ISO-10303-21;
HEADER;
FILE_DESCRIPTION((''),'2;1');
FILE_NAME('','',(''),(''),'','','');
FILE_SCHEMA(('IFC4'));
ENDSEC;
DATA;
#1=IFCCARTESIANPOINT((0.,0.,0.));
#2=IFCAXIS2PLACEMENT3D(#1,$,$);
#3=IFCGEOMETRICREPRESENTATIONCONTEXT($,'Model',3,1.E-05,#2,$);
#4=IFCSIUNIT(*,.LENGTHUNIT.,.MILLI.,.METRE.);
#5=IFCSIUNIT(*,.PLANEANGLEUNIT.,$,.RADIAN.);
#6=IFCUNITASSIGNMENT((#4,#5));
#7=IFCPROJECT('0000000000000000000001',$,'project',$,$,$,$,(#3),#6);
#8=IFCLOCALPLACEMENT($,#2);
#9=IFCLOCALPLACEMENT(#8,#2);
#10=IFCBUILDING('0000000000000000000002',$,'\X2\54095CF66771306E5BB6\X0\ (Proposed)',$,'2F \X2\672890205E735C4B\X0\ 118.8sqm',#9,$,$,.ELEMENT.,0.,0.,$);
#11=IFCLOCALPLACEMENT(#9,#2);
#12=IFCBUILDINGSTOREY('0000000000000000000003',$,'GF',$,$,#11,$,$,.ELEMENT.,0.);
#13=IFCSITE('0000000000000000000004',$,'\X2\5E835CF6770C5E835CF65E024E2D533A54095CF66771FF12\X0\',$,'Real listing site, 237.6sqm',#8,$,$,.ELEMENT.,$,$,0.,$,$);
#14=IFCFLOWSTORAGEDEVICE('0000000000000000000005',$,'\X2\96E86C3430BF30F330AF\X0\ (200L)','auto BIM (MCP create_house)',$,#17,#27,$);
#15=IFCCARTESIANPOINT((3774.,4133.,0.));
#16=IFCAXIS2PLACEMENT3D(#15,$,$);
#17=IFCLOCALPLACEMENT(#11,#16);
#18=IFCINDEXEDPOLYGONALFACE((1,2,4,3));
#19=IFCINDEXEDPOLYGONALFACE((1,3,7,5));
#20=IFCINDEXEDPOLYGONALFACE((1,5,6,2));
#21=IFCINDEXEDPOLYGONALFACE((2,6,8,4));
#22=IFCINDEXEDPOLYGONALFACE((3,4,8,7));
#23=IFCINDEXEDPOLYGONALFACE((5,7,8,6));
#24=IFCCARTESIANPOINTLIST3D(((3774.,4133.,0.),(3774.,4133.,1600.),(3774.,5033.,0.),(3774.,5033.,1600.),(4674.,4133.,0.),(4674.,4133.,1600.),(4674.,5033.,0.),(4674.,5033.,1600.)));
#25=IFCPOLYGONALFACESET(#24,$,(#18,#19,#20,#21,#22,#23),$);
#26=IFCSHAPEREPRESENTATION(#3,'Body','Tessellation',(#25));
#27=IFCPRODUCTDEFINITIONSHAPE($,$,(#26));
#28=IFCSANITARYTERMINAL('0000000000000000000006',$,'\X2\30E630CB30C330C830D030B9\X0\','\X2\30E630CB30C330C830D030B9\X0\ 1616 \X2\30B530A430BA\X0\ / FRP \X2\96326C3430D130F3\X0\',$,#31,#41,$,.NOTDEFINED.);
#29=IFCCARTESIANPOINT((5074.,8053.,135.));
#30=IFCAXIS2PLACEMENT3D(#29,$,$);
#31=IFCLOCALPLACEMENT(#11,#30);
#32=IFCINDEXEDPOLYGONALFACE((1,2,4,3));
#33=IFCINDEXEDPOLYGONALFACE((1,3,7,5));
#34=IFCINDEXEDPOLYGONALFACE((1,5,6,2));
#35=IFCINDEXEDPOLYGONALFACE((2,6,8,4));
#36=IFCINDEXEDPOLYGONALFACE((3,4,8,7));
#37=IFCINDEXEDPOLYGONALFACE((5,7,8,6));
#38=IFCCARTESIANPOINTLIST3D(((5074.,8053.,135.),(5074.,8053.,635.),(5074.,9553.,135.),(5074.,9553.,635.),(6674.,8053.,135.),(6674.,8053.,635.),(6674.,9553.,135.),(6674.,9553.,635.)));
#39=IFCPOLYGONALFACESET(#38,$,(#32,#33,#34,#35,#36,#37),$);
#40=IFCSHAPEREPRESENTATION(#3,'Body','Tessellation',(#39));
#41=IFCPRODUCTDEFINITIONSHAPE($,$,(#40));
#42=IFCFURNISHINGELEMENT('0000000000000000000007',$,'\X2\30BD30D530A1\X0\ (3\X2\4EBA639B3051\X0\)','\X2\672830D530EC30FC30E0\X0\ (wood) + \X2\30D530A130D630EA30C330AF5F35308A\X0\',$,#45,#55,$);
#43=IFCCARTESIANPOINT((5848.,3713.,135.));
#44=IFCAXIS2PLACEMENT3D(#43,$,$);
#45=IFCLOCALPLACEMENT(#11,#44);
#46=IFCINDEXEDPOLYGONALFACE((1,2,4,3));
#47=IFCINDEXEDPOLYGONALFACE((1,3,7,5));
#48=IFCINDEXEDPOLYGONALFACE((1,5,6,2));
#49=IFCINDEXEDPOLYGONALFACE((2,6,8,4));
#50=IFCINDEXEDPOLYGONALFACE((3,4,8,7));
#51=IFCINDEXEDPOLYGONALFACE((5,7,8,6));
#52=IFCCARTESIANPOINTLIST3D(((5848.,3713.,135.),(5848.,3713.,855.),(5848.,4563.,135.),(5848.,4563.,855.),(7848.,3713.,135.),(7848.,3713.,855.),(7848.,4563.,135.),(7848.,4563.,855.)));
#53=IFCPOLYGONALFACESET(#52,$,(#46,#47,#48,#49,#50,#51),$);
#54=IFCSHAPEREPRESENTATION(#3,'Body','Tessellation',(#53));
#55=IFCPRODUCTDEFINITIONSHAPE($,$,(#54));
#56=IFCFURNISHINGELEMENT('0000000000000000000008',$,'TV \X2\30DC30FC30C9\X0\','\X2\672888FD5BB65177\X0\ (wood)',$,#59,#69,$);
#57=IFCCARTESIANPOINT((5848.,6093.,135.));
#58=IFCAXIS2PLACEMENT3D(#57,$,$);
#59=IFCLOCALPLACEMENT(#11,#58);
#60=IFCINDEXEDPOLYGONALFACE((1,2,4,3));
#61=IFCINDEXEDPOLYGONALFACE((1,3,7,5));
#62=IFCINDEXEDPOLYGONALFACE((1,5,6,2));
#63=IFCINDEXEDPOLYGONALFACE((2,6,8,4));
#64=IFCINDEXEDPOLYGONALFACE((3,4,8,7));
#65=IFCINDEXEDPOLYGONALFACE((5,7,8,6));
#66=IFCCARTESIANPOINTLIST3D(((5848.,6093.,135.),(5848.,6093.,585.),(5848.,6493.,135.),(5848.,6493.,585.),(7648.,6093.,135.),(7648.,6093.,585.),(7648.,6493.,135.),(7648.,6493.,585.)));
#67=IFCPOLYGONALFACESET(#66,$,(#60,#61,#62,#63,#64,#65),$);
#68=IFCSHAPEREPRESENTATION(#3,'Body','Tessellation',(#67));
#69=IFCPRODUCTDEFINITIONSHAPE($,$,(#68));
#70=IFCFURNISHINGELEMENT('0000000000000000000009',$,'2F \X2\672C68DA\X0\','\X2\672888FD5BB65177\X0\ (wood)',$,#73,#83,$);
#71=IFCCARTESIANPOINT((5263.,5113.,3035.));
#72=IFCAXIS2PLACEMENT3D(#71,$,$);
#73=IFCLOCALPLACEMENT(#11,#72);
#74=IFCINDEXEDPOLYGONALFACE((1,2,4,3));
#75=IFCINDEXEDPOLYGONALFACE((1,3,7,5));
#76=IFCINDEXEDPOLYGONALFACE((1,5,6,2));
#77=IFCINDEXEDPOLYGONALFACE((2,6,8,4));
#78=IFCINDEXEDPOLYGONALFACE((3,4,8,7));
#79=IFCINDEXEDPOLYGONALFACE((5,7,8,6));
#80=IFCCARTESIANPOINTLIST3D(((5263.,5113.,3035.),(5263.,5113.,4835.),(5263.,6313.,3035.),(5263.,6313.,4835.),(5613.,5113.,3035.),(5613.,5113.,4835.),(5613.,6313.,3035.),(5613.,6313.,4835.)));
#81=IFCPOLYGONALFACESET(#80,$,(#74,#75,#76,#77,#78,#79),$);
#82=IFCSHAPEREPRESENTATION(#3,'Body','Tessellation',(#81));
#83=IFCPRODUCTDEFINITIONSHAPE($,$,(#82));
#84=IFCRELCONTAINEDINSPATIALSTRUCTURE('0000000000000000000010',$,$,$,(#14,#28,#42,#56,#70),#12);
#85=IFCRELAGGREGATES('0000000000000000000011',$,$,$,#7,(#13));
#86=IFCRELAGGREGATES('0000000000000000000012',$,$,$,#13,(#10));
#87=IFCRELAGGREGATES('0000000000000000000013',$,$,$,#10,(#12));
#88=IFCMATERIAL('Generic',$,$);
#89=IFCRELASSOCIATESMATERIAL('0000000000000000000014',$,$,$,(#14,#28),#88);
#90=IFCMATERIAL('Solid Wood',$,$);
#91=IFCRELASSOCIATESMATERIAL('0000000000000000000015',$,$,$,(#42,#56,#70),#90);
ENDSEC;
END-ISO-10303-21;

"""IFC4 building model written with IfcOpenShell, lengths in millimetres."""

from ifc_helpers import new_model, si_unit, frame, frame_2d, origin, place, context, project, spatial, rectangle, extrude, material, element, save


model = new_model("IFC4")

# Units and contexts
model_context = context("Model", 3, precision=1e-05, world=origin())
ifc_project = project(units=[si_unit("LENGTHUNIT", "METRE", prefix="MILLI"), si_unit("PLANEANGLEUNIT", "RADIAN")], contexts=[model_context])

# Site, building, storey
site_placement = place(None, origin())
site = spatial("IfcSite", under=ifc_project, at=site_placement, Name="広島県広島市中区吉島東２", ObjectType="Real listing site, 237.6sqm", CompositionType="ELEMENT", RefElevation=0.0)
building_placement = place(site_placement, origin())
building = spatial("IfcBuilding", under=site, at=building_placement, Name="吉島東の家 (Proposed)", ObjectType="2F 木造平屋 118.8sqm", CompositionType="ELEMENT", ElevationOfRefHeight=0.0, ElevationOfTerrain=0.0)
storey_placement = place(building_placement, origin())
storey = spatial("IfcBuildingStorey", under=building, at=storey_placement, Name="GF", CompositionType="ELEMENT", Elevation=0.0)

# Shared definitions
ifc_material_1 = material(Name="Solid Wood")

# Shared definitions
ifc_material_2 = material(Name="Generic")

# Flow storage device
flow_storage_device_placement = place(storey_placement, frame((3774.0, 4133.0, 0.0)))
element("IfcFlowStorageDevice", 1, at=flow_storage_device_placement, inside=storey, material=ifc_material_2, Name="雨水タンク (200L)", Description="auto BIM (MCP create_house)", context=model_context, shape_type="SweptSolid", body=[
    extrude(rectangle(XDim=900.0, YDim=900.0, at=frame_2d((450.0, 450.0))), frame((3774.0, 4133.0, 0.0)), (0.0, 0.0, 1.0), 1600.0),
])

# Sanitary terminal
sanitary_terminal_placement = place(storey_placement, frame((5074.0, 8053.0, 135.0)))
element("IfcSanitaryTerminal", 2, at=sanitary_terminal_placement, inside=storey, material=ifc_material_2, Name="ユニットバス", Description="ユニットバス 1616 サイズ / FRP 防水パン", PredefinedType="NOTDEFINED", context=model_context, shape_type="SweptSolid", body=[
    extrude(rectangle(XDim=1600.0, YDim=1500.0, at=frame_2d((800.0, 750.0))), frame((5074.0, 8053.0, 135.0)), (0.0, 0.0, 1.0), 500.0),
])

# Furnishing elements
furnishing_1_placement = place(storey_placement, frame((5848.0, 3713.0, 135.0)))
element("IfcFurnishingElement", 3, at=furnishing_1_placement, inside=storey, material=ifc_material_1, Name="ソファ (3人掛け)", Description="木フレーム (wood) + ファブリック張り", context=model_context, shape_type="SweptSolid", body=[
    extrude(rectangle(XDim=2000.0, YDim=850.0, at=frame_2d((1000.0, 425.0))), frame((5848.0, 3713.0, 135.0)), (0.0, 0.0, 1.0), 720.0),
])
furnishing_2_placement = place(storey_placement, frame((5848.0, 6093.0, 135.0)))
element("IfcFurnishingElement", 4, at=furnishing_2_placement, inside=storey, material=ifc_material_1, Name="TV ボード", Description="木製家具 (wood)", context=model_context, shape_type="SweptSolid", body=[
    extrude(rectangle(XDim=1800.0, YDim=400.0, at=frame_2d((900.0, 200.0))), frame((5848.0, 6093.0, 135.0)), (0.0, 0.0, 1.0), 450.0),
])
furnishing_3_placement = place(storey_placement, frame((5263.0, 5113.0, 3035.0)))
element("IfcFurnishingElement", 5, at=furnishing_3_placement, inside=storey, material=ifc_material_1, Name="2F 本棚", Description="木製家具 (wood)", context=model_context, shape_type="SweptSolid", body=[
    extrude(rectangle(XDim=350.0, YDim=1200.0, at=frame_2d((175.0, 600.0))), frame((5263.0, 5113.0, 3035.0)), (0.0, 0.0, 1.0), 1800.0),
])

save(model, "model.ifc")
